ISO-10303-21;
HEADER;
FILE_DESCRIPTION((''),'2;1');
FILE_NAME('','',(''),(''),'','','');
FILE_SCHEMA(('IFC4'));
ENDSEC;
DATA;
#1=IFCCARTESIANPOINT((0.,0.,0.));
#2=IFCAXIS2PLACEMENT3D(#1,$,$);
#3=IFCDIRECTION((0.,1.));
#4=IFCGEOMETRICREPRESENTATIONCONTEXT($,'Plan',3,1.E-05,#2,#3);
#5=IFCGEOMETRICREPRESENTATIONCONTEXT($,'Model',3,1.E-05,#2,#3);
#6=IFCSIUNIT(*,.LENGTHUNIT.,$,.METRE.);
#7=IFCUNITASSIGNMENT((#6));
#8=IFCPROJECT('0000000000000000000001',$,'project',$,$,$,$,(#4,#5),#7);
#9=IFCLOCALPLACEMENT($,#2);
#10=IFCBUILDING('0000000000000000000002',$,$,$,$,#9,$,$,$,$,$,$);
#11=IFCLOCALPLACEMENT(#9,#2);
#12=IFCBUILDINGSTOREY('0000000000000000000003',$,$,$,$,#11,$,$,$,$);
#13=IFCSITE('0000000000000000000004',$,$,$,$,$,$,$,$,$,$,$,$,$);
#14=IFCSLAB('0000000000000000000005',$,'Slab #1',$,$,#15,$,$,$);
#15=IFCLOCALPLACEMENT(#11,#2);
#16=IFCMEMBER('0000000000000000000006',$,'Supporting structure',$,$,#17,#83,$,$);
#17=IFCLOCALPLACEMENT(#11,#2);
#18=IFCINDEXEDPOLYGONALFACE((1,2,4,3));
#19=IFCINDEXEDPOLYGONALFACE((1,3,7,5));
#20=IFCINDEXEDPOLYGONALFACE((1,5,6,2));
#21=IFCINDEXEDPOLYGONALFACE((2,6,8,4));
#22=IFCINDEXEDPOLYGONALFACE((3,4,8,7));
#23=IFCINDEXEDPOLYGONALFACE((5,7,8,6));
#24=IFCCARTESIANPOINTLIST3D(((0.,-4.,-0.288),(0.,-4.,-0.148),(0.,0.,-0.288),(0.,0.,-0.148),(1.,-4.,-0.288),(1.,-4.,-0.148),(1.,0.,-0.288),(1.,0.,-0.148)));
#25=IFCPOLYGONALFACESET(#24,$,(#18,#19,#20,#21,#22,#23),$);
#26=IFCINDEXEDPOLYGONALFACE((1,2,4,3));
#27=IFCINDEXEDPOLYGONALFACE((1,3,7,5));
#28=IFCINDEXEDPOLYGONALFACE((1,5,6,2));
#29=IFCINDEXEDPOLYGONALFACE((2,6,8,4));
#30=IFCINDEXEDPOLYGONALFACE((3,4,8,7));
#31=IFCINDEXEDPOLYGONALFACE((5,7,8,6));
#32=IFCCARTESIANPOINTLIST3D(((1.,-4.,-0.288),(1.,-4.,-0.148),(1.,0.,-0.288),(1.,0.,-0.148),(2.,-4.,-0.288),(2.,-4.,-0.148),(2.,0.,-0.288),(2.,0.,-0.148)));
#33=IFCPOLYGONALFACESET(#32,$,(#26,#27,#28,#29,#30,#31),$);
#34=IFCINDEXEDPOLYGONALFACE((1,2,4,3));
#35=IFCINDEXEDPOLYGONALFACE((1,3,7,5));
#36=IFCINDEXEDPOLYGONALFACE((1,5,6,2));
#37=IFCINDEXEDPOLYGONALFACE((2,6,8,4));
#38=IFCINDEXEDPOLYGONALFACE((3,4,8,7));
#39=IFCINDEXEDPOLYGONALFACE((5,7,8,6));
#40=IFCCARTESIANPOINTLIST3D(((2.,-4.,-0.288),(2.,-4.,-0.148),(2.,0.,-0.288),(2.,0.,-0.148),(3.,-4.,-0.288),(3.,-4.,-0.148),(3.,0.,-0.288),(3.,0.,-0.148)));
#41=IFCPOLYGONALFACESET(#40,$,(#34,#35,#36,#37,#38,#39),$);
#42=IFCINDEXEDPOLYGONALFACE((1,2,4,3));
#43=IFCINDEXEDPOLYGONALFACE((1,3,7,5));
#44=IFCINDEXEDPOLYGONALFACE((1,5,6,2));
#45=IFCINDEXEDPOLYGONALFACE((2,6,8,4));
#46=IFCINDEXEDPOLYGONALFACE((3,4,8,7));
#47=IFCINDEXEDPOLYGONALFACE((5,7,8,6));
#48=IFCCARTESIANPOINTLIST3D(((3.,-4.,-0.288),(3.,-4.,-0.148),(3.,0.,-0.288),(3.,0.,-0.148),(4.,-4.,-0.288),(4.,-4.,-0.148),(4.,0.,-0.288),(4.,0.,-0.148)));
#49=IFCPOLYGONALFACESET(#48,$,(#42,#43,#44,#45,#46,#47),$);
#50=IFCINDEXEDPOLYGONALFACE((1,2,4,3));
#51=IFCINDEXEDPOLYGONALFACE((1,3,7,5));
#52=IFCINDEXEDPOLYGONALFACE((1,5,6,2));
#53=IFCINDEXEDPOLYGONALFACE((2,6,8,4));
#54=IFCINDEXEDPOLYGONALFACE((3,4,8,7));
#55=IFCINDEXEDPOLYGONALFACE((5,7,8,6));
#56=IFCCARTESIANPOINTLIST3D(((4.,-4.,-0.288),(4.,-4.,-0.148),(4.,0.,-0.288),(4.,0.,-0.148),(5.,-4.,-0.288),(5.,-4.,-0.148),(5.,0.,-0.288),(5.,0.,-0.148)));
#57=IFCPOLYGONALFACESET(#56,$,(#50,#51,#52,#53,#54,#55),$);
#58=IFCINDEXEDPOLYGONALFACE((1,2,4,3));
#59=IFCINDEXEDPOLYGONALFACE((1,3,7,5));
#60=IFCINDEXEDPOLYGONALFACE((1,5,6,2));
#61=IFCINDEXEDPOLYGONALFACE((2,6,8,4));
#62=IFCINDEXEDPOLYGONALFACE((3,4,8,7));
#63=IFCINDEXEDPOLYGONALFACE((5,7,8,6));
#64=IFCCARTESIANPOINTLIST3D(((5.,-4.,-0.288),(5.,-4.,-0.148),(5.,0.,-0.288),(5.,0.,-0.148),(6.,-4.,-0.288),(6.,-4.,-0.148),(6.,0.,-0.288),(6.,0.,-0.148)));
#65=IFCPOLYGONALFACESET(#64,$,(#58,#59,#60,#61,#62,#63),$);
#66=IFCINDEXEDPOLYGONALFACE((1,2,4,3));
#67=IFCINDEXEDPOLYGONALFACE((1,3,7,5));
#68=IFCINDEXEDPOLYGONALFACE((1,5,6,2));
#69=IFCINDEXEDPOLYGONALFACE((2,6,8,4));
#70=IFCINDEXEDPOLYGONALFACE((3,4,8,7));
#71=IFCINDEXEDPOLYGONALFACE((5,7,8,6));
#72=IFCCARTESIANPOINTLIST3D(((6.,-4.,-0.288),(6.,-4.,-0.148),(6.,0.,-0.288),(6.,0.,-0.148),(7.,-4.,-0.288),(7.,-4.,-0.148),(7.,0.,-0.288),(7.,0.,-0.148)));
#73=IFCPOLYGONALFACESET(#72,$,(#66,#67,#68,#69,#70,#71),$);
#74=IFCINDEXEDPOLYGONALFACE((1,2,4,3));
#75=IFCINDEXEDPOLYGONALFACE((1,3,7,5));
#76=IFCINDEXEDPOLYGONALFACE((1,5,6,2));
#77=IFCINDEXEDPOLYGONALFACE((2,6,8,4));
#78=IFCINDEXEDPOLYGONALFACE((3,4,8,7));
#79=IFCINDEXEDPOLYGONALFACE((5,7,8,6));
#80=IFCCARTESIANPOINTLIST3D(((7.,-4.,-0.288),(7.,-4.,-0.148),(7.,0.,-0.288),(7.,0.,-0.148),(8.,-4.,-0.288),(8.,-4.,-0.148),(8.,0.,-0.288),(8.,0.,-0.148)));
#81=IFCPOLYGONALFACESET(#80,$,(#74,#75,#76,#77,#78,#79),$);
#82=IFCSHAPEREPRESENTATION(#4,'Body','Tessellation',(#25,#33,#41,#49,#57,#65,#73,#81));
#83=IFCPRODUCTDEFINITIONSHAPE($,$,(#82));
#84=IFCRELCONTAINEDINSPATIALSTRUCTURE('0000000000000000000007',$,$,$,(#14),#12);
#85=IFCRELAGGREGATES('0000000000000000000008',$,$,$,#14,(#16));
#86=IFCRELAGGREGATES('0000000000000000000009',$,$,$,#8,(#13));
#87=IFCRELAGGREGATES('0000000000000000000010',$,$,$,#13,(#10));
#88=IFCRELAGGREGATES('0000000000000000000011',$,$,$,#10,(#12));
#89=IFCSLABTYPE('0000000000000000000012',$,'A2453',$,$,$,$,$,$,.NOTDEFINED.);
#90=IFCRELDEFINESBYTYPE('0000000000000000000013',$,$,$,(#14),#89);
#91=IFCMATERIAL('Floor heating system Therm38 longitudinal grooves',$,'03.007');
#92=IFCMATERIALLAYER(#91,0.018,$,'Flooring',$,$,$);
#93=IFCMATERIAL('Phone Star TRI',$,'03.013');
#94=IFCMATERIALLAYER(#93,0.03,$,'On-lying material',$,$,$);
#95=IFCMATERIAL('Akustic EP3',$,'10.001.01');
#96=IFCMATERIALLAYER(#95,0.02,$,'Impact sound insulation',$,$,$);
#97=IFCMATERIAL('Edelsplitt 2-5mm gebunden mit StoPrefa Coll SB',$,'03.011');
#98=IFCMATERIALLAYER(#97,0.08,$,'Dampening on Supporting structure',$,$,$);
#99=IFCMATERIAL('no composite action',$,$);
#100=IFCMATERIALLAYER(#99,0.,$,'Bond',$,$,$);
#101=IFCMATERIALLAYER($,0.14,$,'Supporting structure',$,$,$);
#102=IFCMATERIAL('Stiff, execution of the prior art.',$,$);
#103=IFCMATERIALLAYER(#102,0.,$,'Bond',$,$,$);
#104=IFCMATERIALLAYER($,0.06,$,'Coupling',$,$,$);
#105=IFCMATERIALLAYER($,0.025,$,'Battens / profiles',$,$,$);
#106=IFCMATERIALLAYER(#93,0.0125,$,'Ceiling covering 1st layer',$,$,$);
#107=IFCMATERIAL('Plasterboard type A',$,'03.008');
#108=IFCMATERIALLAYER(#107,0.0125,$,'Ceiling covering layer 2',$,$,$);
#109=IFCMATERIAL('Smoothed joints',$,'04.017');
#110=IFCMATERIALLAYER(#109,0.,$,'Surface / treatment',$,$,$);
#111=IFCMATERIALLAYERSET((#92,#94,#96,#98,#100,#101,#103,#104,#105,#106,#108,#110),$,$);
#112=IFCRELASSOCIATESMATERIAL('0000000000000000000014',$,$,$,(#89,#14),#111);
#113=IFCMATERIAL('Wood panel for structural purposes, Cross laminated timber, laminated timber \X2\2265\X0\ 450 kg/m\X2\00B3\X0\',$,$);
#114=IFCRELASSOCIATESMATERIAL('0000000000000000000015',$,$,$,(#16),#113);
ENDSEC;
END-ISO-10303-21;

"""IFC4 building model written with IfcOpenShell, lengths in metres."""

from ifc_helpers import new_model, si_unit, direction, frame, frame_2d, origin, place, context, project, spatial, rectangle, extrude, material, layer, layer_set, type_object, element, aggregate, save


model = new_model("IFC4")

# Units and contexts
plan_context = context("Plan", 3, precision=1e-05, world=origin(), true_north=direction((0.0, 1.0)))
model_context = context("Model", 3, precision=1e-05, world=origin(), true_north=direction((0.0, 1.0)))
ifc_project = project(units=[si_unit("LENGTHUNIT", "METRE")], contexts=[plan_context, model_context])

# Site, building, storey
site = spatial("IfcSite", under=ifc_project)
building_placement = place(None, origin())
building = spatial("IfcBuilding", under=site, at=building_placement)
storey_placement = place(building_placement, origin())
storey = spatial("IfcBuildingStorey", under=building, at=storey_placement)

# Slab, member
ifc_material_1 = material(Name="Floor heating system Therm38 longitudinal grooves", Category="03.007")
ifc_layer_1 = layer(ifc_material_1, 0.018, Name="Flooring")
ifc_material_2 = material(Name="Phone Star TRI", Category="03.013")
ifc_layer_2 = layer(ifc_material_2, 0.03, Name="On-lying material")
ifc_material_3 = material(Name="Akustic EP3", Category="10.001.01")
ifc_layer_3 = layer(ifc_material_3, 0.02, Name="Impact sound insulation")
ifc_material_4 = material(Name="Edelsplitt 2-5mm gebunden mit StoPrefa Coll SB", Category="03.011")
ifc_layer_4 = layer(ifc_material_4, 0.08, Name="Dampening on Supporting structure")
ifc_material_5 = material(Name="no composite action")
ifc_layer_5 = layer(ifc_material_5, 0.0, Name="Bond")
ifc_layer_6 = layer(None, 0.14, Name="Supporting structure")
ifc_material_6 = material(Name="Stiff, execution of the prior art.")
ifc_layer_7 = layer(ifc_material_6, 0.0, Name="Bond")
ifc_layer_8 = layer(None, 0.06, Name="Coupling")
ifc_layer_9 = layer(None, 0.025, Name="Battens / profiles")
ifc_layer_10 = layer(ifc_material_2, 0.0125, Name="Ceiling covering 1st layer")
ifc_material_7 = material(Name="Plasterboard type A", Category="03.008")
ifc_layer_11 = layer(ifc_material_7, 0.0125, Name="Ceiling covering layer 2")
ifc_material_8 = material(Name="Smoothed joints", Category="04.017")
ifc_layer_12 = layer(ifc_material_8, 0.0, Name="Surface / treatment")
ifc_layer_set = layer_set([ifc_layer_1, ifc_layer_2, ifc_layer_3, ifc_layer_4, ifc_layer_5, ifc_layer_6, ifc_layer_7, ifc_layer_8, ifc_layer_9, ifc_layer_10, ifc_layer_11, ifc_layer_12])
slab_type = type_object("IfcSlabType", Name="A2453", PredefinedType="NOTDEFINED", material=ifc_layer_set)
slab_placement = place(None, frame((0.0, 0.0, 0.0), z_axis=(0.0, 0.0, -1.0), x_axis=(1.0, 0.0, 0.0)))
slab = element("IfcSlab", 1, at=slab_placement, inside=storey, type_object=slab_type, material=ifc_layer_set, Name="Slab #1")
ifc_material_9 = material(Name="Wood panel for structural purposes, Cross laminated timber, laminated timber ≥ 450 kg/m³")
member_1_placement = place(slab_placement, origin())
member_1 = element("IfcMember", 2, at=member_1_placement, material=ifc_material_9, Name="Supporting structure", context=plan_context, shape_type="SweptSolid", body=[
    extrude(rectangle(XDim=1.0, YDim=0.14, at=frame_2d((0.5, 0.07), x_axis=(1.0, 0.0))), frame((0.0, 4.0, 0.148), z_axis=(0.0, -1.0, 0.0), x_axis=(1.0, 0.0, 0.0)), (0.0, 0.0, 1.0), 4.0),
    extrude(rectangle(XDim=1.0, YDim=0.14, at=frame_2d((0.5, 0.07), x_axis=(1.0, 0.0))), frame((1.0, 4.0, 0.148), z_axis=(0.0, -1.0, 0.0), x_axis=(1.0, 0.0, 0.0)), (0.0, 0.0, 1.0), 4.0),
    extrude(rectangle(XDim=1.0, YDim=0.14, at=frame_2d((0.5, 0.07), x_axis=(1.0, 0.0))), frame((2.0, 4.0, 0.148), z_axis=(0.0, -1.0, 0.0), x_axis=(1.0, 0.0, 0.0)), (0.0, 0.0, 1.0), 4.0),
    extrude(rectangle(XDim=1.0, YDim=0.14, at=frame_2d((0.5, 0.07), x_axis=(1.0, 0.0))), frame((3.0, 4.0, 0.148), z_axis=(0.0, -1.0, 0.0), x_axis=(1.0, 0.0, 0.0)), (0.0, 0.0, 1.0), 4.0),
    extrude(rectangle(XDim=1.0, YDim=0.14, at=frame_2d((0.5, 0.07), x_axis=(1.0, 0.0))), frame((4.0, 4.0, 0.148), z_axis=(0.0, -1.0, 0.0), x_axis=(1.0, 0.0, 0.0)), (0.0, 0.0, 1.0), 4.0),
    extrude(rectangle(XDim=1.0, YDim=0.14, at=frame_2d((0.5, 0.07), x_axis=(1.0, 0.0))), frame((5.0, 4.0, 0.148), z_axis=(0.0, -1.0, 0.0), x_axis=(1.0, 0.0, 0.0)), (0.0, 0.0, 1.0), 4.0),
    extrude(rectangle(XDim=1.0, YDim=0.14, at=frame_2d((0.5, 0.07), x_axis=(1.0, 0.0))), frame((6.0, 4.0, 0.148), z_axis=(0.0, -1.0, 0.0), x_axis=(1.0, 0.0, 0.0)), (0.0, 0.0, 1.0), 4.0),
    extrude(rectangle(XDim=1.0, YDim=0.14, at=frame_2d((0.5, 0.07), x_axis=(1.0, 0.0))), frame((7.0, 4.0, 0.148), z_axis=(0.0, -1.0, 0.0), x_axis=(1.0, 0.0, 0.0)), (0.0, 0.0, 1.0), 4.0),
])
aggregate(slab, [member_1])

save(model, "model.ifc")
